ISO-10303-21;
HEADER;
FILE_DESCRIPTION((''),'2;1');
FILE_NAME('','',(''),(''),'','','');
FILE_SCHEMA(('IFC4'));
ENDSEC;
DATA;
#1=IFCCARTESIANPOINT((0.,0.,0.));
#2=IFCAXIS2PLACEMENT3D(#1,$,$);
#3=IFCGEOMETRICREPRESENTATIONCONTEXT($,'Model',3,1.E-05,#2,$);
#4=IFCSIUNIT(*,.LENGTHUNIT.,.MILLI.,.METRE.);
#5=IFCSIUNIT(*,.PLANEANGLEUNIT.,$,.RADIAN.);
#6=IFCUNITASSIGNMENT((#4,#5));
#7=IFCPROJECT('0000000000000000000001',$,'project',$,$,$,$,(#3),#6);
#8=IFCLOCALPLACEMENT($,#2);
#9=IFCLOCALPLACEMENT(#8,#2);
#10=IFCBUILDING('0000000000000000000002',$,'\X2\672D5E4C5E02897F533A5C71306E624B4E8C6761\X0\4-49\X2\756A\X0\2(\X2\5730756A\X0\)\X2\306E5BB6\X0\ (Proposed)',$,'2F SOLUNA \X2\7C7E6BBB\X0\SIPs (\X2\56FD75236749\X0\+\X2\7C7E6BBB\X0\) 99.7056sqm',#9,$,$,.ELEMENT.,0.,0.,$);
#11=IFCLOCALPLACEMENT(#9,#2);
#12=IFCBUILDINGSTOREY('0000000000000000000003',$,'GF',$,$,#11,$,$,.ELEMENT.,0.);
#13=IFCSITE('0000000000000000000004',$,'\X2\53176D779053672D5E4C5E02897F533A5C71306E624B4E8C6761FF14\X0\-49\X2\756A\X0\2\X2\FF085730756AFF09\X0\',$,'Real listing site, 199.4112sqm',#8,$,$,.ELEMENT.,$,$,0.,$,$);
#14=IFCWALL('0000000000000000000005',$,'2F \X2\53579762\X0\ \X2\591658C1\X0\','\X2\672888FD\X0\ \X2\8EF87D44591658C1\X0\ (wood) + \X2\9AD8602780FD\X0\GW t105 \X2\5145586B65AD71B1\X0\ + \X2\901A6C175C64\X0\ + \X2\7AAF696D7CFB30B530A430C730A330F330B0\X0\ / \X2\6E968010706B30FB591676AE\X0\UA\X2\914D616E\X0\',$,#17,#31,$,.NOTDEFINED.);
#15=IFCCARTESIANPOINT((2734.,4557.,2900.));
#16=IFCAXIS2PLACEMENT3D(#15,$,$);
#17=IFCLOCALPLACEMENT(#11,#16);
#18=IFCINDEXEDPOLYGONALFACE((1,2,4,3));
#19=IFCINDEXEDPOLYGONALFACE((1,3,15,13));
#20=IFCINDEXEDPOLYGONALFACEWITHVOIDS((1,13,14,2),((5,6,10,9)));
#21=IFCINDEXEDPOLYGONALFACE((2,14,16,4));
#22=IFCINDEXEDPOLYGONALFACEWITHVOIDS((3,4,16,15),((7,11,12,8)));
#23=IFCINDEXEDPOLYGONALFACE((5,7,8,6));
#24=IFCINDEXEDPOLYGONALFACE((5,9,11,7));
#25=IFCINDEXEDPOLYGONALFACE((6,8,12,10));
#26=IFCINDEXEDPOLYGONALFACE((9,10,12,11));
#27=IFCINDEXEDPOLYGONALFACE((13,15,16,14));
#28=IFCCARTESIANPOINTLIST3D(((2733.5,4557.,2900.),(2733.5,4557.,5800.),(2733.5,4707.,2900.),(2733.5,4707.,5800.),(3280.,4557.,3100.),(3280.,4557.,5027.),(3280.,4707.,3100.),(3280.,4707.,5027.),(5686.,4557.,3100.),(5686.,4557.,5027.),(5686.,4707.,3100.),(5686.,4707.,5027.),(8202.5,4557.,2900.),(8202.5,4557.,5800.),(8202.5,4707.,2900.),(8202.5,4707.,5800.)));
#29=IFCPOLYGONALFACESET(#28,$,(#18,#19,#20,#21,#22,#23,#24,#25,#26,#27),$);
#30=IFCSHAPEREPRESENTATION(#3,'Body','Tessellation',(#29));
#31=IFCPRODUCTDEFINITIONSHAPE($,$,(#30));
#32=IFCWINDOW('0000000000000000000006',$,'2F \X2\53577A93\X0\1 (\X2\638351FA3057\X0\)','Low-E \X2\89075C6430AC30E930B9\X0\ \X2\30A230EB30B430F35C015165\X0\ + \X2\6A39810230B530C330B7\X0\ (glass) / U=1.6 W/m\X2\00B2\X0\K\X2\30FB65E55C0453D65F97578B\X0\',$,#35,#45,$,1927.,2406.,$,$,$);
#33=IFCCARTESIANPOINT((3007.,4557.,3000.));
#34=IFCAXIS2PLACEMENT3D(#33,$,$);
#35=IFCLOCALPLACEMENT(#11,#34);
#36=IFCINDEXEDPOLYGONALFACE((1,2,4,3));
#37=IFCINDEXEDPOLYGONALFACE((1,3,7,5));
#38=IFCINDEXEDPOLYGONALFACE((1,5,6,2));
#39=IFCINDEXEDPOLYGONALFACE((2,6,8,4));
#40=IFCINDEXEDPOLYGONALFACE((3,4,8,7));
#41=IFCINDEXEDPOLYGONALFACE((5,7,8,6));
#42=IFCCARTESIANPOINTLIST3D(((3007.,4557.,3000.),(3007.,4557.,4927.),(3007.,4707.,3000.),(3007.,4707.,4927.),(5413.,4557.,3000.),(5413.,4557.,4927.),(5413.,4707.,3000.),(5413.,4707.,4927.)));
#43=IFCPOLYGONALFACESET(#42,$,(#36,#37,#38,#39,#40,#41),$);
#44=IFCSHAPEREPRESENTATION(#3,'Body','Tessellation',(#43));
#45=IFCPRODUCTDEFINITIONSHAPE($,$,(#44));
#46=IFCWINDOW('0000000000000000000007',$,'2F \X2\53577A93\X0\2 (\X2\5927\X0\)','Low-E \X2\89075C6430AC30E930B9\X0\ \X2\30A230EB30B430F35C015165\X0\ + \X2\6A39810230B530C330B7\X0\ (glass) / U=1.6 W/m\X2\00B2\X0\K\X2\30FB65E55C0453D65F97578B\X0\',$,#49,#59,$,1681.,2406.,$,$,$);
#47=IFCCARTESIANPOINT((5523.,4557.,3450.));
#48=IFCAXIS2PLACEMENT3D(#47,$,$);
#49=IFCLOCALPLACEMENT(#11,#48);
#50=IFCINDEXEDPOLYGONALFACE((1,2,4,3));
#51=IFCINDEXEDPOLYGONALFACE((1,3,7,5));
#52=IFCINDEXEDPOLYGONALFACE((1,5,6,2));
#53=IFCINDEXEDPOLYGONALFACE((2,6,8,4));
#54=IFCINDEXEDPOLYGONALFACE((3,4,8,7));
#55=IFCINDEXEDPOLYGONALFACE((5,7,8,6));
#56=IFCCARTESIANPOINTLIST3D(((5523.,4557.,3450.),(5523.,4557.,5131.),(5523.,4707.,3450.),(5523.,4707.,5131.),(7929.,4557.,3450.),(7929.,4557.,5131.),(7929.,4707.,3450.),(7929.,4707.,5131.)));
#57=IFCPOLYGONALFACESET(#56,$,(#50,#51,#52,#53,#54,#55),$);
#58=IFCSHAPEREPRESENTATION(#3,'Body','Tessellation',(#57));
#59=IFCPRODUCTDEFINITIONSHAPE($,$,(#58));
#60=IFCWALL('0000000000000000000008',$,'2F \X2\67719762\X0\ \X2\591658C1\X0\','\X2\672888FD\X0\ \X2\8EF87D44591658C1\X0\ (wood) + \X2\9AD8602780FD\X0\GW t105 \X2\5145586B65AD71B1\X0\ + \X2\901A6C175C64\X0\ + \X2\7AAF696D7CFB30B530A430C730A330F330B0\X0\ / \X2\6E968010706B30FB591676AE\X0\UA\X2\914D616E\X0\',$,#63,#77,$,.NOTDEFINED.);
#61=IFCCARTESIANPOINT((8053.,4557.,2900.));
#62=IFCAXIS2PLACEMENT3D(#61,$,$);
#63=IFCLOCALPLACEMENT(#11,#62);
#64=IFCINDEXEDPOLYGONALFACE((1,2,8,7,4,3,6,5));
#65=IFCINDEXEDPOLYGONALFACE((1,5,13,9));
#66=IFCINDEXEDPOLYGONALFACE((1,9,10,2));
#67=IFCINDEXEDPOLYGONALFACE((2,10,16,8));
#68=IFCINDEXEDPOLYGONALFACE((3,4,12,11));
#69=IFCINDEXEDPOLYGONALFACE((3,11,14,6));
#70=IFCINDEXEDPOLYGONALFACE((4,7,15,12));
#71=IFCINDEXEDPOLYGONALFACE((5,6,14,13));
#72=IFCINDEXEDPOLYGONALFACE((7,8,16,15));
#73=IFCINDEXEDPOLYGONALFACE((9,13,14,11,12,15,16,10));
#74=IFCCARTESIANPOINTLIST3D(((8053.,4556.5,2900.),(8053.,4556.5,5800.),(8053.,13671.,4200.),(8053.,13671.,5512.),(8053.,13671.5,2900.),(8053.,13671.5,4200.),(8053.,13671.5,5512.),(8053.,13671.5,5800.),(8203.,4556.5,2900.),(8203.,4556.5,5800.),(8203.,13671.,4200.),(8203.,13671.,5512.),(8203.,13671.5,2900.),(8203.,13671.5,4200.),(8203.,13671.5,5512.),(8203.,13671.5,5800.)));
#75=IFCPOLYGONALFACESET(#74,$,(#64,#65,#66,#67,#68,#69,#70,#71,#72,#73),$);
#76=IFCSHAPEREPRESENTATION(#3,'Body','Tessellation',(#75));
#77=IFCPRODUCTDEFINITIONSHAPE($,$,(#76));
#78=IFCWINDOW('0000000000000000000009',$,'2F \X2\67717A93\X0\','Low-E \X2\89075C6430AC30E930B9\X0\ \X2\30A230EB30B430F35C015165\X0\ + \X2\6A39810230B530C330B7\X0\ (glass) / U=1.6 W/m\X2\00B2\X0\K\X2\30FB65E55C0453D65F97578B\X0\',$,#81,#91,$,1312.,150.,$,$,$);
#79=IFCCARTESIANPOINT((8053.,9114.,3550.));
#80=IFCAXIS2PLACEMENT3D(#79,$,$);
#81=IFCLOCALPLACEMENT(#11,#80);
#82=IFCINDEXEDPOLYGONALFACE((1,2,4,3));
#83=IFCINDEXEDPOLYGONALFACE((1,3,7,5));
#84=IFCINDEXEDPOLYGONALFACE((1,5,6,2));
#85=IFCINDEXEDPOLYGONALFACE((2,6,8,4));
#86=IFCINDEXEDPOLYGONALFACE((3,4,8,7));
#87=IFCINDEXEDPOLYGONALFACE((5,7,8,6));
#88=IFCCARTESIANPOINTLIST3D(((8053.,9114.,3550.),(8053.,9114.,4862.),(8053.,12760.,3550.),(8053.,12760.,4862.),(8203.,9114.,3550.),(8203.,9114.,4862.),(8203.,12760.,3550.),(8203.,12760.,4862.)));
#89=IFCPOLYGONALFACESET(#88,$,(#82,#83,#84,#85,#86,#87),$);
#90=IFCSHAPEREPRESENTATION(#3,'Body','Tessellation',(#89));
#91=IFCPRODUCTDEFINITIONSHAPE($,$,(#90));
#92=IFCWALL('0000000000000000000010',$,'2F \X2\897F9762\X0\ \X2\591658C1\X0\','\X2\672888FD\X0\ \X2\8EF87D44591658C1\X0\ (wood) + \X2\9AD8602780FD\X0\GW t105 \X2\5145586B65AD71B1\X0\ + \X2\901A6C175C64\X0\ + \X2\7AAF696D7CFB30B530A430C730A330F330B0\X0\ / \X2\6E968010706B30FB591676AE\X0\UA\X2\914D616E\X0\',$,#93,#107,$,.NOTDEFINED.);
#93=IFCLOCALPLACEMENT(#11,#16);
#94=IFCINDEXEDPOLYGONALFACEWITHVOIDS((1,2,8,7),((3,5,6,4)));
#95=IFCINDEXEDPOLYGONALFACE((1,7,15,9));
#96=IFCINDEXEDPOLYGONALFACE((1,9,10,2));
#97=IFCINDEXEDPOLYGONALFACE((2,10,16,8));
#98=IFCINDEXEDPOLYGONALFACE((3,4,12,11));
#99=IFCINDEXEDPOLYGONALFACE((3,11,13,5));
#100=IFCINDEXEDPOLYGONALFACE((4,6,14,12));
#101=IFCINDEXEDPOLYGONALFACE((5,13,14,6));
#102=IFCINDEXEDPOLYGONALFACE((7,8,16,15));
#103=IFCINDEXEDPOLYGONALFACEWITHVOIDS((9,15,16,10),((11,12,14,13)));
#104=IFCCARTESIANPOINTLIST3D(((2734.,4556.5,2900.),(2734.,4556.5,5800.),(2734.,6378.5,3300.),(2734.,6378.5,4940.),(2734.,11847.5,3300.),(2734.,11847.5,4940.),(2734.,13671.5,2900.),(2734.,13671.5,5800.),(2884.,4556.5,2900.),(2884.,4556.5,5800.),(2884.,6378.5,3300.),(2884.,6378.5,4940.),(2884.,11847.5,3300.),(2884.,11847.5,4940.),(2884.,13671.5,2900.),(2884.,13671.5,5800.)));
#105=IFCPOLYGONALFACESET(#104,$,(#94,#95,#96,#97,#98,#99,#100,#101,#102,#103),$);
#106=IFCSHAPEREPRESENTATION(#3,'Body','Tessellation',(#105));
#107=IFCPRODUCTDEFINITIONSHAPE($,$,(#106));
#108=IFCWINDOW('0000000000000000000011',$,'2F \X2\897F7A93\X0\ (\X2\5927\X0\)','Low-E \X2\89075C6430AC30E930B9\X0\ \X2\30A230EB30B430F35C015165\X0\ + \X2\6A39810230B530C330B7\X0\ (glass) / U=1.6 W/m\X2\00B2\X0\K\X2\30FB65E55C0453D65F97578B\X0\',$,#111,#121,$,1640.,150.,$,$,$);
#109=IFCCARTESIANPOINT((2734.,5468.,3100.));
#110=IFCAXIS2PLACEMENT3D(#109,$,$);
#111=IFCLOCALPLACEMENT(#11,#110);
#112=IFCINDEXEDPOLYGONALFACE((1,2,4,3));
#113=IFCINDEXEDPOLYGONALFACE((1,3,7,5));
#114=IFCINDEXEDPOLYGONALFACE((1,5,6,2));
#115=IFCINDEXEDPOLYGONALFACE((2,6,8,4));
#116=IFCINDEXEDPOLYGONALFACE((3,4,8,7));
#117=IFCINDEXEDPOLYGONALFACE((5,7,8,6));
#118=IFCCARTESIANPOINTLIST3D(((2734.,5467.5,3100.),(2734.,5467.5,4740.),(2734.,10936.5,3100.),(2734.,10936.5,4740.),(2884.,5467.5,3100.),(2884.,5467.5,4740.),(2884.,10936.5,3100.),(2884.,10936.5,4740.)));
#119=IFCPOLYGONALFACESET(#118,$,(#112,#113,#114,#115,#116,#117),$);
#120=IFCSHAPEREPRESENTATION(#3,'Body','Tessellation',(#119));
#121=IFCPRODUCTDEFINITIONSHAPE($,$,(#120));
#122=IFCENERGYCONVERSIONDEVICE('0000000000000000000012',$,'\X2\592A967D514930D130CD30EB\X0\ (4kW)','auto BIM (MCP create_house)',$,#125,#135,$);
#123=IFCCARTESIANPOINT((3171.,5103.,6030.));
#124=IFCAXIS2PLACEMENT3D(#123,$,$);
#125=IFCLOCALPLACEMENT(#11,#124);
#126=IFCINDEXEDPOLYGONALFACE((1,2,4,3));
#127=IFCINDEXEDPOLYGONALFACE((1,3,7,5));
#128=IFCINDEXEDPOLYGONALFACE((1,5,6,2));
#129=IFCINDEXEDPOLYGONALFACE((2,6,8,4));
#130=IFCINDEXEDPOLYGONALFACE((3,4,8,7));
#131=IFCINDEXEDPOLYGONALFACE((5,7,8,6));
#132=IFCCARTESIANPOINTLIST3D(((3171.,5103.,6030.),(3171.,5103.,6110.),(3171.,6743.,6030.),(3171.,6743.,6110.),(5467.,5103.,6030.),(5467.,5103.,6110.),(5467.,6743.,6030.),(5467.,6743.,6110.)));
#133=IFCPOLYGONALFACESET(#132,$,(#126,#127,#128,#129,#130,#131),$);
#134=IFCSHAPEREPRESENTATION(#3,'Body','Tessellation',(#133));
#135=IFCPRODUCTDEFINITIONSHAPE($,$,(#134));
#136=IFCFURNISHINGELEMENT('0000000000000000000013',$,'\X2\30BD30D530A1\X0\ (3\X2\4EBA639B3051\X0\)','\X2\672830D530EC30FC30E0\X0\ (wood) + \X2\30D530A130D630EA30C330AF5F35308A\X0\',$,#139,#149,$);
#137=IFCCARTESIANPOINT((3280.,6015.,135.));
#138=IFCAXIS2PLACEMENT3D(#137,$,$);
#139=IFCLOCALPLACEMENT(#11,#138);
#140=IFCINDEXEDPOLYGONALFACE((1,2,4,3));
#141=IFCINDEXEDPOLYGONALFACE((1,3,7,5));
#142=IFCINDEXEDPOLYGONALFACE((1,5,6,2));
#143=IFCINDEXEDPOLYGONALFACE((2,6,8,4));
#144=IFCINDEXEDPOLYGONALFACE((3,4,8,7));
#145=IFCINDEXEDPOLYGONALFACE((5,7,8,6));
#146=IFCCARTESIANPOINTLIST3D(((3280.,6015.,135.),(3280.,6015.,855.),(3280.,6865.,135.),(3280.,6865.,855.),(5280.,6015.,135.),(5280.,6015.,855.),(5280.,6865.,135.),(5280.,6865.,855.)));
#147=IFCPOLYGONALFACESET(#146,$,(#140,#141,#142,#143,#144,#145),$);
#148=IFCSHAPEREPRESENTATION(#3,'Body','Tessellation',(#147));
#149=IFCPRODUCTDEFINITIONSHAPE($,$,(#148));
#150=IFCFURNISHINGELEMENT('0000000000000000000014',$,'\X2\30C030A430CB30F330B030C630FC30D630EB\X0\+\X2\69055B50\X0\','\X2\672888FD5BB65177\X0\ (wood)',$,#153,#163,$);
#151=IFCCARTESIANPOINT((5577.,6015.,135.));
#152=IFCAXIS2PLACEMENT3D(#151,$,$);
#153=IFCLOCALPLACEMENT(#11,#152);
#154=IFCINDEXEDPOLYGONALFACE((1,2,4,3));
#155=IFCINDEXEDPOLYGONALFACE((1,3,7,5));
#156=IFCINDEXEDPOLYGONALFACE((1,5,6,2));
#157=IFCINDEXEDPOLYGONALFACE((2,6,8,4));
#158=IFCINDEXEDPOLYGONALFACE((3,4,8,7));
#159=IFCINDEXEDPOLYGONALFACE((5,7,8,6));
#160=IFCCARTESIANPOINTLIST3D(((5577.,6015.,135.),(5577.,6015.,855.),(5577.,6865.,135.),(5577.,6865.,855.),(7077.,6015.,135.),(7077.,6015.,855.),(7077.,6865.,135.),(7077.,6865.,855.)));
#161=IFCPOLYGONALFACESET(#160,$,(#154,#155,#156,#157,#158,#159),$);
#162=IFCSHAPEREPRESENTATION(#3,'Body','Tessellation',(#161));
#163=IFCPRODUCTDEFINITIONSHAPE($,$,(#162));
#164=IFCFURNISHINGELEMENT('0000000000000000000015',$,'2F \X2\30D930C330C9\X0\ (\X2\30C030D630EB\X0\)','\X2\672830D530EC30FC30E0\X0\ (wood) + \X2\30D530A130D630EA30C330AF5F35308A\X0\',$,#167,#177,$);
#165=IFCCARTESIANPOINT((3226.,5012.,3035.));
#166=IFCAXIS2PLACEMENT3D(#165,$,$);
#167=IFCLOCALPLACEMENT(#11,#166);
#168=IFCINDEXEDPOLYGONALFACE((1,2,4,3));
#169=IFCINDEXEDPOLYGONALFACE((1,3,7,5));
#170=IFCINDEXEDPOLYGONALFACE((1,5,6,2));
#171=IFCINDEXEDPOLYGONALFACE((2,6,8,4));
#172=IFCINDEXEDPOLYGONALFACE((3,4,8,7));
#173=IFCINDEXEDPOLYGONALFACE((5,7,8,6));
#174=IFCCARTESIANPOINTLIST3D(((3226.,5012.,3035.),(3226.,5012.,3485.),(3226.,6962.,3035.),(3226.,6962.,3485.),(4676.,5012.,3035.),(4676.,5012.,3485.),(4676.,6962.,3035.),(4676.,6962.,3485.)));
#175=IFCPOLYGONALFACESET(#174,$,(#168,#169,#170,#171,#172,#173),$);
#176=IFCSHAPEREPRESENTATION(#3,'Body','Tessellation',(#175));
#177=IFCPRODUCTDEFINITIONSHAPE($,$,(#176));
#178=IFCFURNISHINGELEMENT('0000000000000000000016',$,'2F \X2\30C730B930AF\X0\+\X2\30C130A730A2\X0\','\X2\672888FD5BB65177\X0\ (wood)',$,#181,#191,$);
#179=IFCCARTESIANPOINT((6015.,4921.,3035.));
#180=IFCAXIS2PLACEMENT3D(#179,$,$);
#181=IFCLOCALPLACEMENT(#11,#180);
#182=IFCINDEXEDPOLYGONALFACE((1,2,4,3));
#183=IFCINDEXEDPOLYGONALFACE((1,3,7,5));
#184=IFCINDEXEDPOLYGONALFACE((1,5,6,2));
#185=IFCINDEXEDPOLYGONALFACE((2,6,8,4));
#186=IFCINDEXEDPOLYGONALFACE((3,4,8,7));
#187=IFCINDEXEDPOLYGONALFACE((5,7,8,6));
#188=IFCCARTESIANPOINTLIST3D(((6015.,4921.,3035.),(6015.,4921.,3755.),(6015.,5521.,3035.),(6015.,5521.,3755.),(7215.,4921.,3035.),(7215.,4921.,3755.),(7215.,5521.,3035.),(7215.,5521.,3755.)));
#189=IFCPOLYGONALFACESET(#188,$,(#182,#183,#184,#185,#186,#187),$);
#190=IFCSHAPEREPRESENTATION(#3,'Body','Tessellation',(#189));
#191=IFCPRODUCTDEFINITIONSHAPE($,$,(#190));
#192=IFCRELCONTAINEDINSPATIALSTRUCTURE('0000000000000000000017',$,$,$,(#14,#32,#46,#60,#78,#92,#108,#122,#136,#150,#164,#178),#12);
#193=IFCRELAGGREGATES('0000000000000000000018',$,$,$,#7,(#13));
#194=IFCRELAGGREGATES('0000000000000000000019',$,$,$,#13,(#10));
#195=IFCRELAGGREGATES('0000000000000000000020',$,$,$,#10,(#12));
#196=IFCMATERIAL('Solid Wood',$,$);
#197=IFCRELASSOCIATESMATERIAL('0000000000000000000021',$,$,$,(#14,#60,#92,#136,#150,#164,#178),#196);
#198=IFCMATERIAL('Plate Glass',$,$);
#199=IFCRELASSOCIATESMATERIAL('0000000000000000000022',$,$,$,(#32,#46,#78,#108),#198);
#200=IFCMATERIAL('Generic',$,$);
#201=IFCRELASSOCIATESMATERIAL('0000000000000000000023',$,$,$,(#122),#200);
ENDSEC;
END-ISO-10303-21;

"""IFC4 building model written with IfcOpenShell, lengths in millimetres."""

from ifc_helpers import new_model, si_unit, frame, frame_2d, origin, place, context, project, spatial, rectangle, extrude, material, element, fill, save


model = new_model("IFC4")

# Units and contexts
model_context = context("Model", 3, precision=1e-05, world=origin())
ifc_project = project(units=[si_unit("LENGTHUNIT", "METRE", prefix="MILLI"), si_unit("PLANEANGLEUNIT", "RADIAN")], contexts=[model_context])

# Site, building, storey
site_placement = place(None, origin())
site = spatial("IfcSite", under=ifc_project, at=site_placement, Name="北海道札幌市西区山の手二条４-49番2（地番）", ObjectType="Real listing site, 199.4112sqm", CompositionType="ELEMENT", RefElevation=0.0)
building_placement = place(site_placement, origin())
building = spatial("IfcBuilding", under=site, at=building_placement, Name="札幌市西区山の手二条4-49番2(地番)の家 (Proposed)", ObjectType="2F SOLUNA 籾殻SIPs (国産杉+籾殻) 99.7056sqm", CompositionType="ELEMENT", ElevationOfRefHeight=0.0, ElevationOfTerrain=0.0)
storey_placement = place(building_placement, origin())
storey = spatial("IfcBuildingStorey", under=building, at=storey_placement, Name="GF", CompositionType="ELEMENT", Elevation=0.0)

# Shared definitions
ifc_material_1 = material(Name="Solid Wood")

# Wall, openings, windows
wall_1_placement = place(storey_placement, frame((2734.0, 4557.0, 2900.0)))
wall_1 = element("IfcWall", 1, at=wall_1_placement, inside=storey, material=ifc_material_1, Name="2F 南面 外壁", Description="木製 軸組外壁 (wood) + 高性能GW t105 充填断熱 + 通気層 + 窯業系サイディング / 準耐火・外皮UA配慮", PredefinedType="NOTDEFINED", context=model_context, shape_type="SweptSolid", body=[
    extrude(rectangle(XDim=5469.0, YDim=150.0, at=frame_2d((2734.0, 75.0))), frame((2734.0, 4557.0, 2900.0)), (0.0, 0.0, 1.0), 2900.0),
])
opening_1_placement = place(storey_placement, frame((3007.0, 4557.0, 3000.0)))
opening_1 = element("IfcOpeningElement", 2, at=opening_1_placement, cuts=wall_1, PredefinedType="NOTDEFINED", context=model_context, shape_type="SweptSolid", body=[
    extrude(rectangle(XDim=2406.0, YDim=150.0, at=frame_2d((1203.0, 75.0))), frame((3007.0, 4557.0, 3000.0)), (0.0, 0.0, 1.0), 1927.0),
])
opening_2_placement = place(storey_placement, frame((5523.0, 4557.0, 3450.0)))
opening_2 = element("IfcOpeningElement", 3, at=opening_2_placement, cuts=wall_1, PredefinedType="NOTDEFINED", context=model_context, shape_type="SweptSolid", body=[
    extrude(rectangle(XDim=2406.0, YDim=150.0, at=frame_2d((1203.0, 75.0))), frame((5523.0, 4557.0, 3450.0)), (0.0, 0.0, 1.0), 1681.0),
])
ifc_material_2 = material(Name="Plate Glass")
window_1_placement = place(storey_placement, frame((3007.0, 4557.0, 3000.0)))
window_1 = element("IfcWindow", 4, at=window_1_placement, inside=storey, material=ifc_material_2, Name="2F 南窓1 (掃出し)", Description="Low-E 複層ガラス アルゴン封入 + 樹脂サッシ (glass) / U=1.6 W/m²K・日射取得型", OverallHeight=1927.0, OverallWidth=2406.0, context=model_context, shape_type="SweptSolid", body=[
    extrude(rectangle(XDim=2406.0, YDim=150.0, at=frame_2d((1203.0, 75.0))), frame((3007.0, 4557.0, 3000.0)), (0.0, 0.0, 1.0), 1927.0),
])
fill(opening_1, window_1)
window_2_placement = place(storey_placement, frame((5523.0, 4557.0, 3450.0)))
window_2 = element("IfcWindow", 5, at=window_2_placement, inside=storey, material=ifc_material_2, Name="2F 南窓2 (大)", Description="Low-E 複層ガラス アルゴン封入 + 樹脂サッシ (glass) / U=1.6 W/m²K・日射取得型", OverallHeight=1681.0, OverallWidth=2406.0, context=model_context, shape_type="SweptSolid", body=[
    extrude(rectangle(XDim=2406.0, YDim=150.0, at=frame_2d((1203.0, 75.0))), frame((5523.0, 4557.0, 3450.0)), (0.0, 0.0, 1.0), 1681.0),
])
fill(opening_2, window_2)

# Walls, openings, windows
wall_2_placement = place(storey_placement, frame((8053.0, 4557.0, 2900.0)))
wall_2 = element("IfcWall", 6, at=wall_2_placement, inside=storey, material=ifc_material_1, Name="2F 東面 外壁", Description="木製 軸組外壁 (wood) + 高性能GW t105 充填断熱 + 通気層 + 窯業系サイディング / 準耐火・外皮UA配慮", PredefinedType="NOTDEFINED", context=model_context, shape_type="SweptSolid", body=[
    extrude(rectangle(XDim=150.0, YDim=9115.0, at=frame_2d((75.0, 4557.0))), frame((8053.0, 4557.0, 2900.0)), (0.0, 0.0, 1.0), 2900.0),
])
opening_3_placement = place(storey_placement, frame((8053.0, 9114.0, 3550.0)))
opening_3 = element("IfcOpeningElement", 7, at=opening_3_placement, cuts=wall_2, PredefinedType="NOTDEFINED", context=model_context, shape_type="SweptSolid", body=[
    extrude(rectangle(XDim=150.0, YDim=3646.0, at=frame_2d((75.0, 1823.0))), frame((8053.0, 9114.0, 3550.0)), (0.0, 0.0, 1.0), 1312.0),
])
window_3_placement = place(storey_placement, frame((8053.0, 9114.0, 3550.0)))
window_3 = element("IfcWindow", 8, at=window_3_placement, inside=storey, material=ifc_material_2, Name="2F 東窓", Description="Low-E 複層ガラス アルゴン封入 + 樹脂サッシ (glass) / U=1.6 W/m²K・日射取得型", OverallHeight=1312.0, OverallWidth=150.0, context=model_context, shape_type="SweptSolid", body=[
    extrude(rectangle(XDim=150.0, YDim=3646.0, at=frame_2d((75.0, 1823.0))), frame((8053.0, 9114.0, 3550.0)), (0.0, 0.0, 1.0), 1312.0),
])
fill(opening_3, window_3)
wall_3_placement = place(storey_placement, frame((2734.0, 4557.0, 2900.0)))
wall_3 = element("IfcWall", 9, at=wall_3_placement, inside=storey, material=ifc_material_1, Name="2F 西面 外壁", Description="木製 軸組外壁 (wood) + 高性能GW t105 充填断熱 + 通気層 + 窯業系サイディング / 準耐火・外皮UA配慮", PredefinedType="NOTDEFINED", context=model_context, shape_type="SweptSolid", body=[
    extrude(rectangle(XDim=150.0, YDim=9115.0, at=frame_2d((75.0, 4557.0))), frame((2734.0, 4557.0, 2900.0)), (0.0, 0.0, 1.0), 2900.0),
])
opening_4_placement = place(storey_placement, frame((2734.0, 5468.0, 3100.0)))
opening_4 = element("IfcOpeningElement", 10, at=opening_4_placement, cuts=wall_3, PredefinedType="NOTDEFINED", context=model_context, shape_type="SweptSolid", body=[
    extrude(rectangle(XDim=150.0, YDim=5469.0, at=frame_2d((75.0, 2734.0))), frame((2734.0, 5468.0, 3100.0)), (0.0, 0.0, 1.0), 1640.0),
])
window_4_placement = place(storey_placement, frame((2734.0, 5468.0, 3100.0)))
window_4 = element("IfcWindow", 11, at=window_4_placement, inside=storey, material=ifc_material_2, Name="2F 西窓 (大)", Description="Low-E 複層ガラス アルゴン封入 + 樹脂サッシ (glass) / U=1.6 W/m²K・日射取得型", OverallHeight=1640.0, OverallWidth=150.0, context=model_context, shape_type="SweptSolid", body=[
    extrude(rectangle(XDim=150.0, YDim=5469.0, at=frame_2d((75.0, 2734.0))), frame((2734.0, 5468.0, 3100.0)), (0.0, 0.0, 1.0), 1640.0),
])
fill(opening_4, window_4)

# Shared definitions
ifc_material_3 = material(Name="Generic")

# Energy conversion device
energy_conversion_device_placement = place(storey_placement, frame((3171.0, 5103.0, 6030.0)))
element("IfcEnergyConversionDevice", 12, at=energy_conversion_device_placement, inside=storey, material=ifc_material_3, Name="太陽光パネル (4kW)", Description="auto BIM (MCP create_house)", context=model_context, shape_type="SweptSolid", body=[
    extrude(rectangle(XDim=2296.0, YDim=1640.0, at=frame_2d((1148.0, 820.0))), frame((3171.0, 5103.0, 6030.0)), (0.0, 0.0, 1.0), 80.0),
])

# Furnishing elements
furnishing_1_placement = place(storey_placement, frame((3280.0, 6015.0, 135.0)))
element("IfcFurnishingElement", 13, at=furnishing_1_placement, inside=storey, material=ifc_material_1, Name="ソファ (3人掛け)", Description="木フレーム (wood) + ファブリック張り", context=model_context, shape_type="SweptSolid", body=[
    extrude(rectangle(XDim=2000.0, YDim=850.0, at=frame_2d((1000.0, 425.0))), frame((3280.0, 6015.0, 135.0)), (0.0, 0.0, 1.0), 720.0),
])
furnishing_2_placement = place(storey_placement, frame((5577.0, 6015.0, 135.0)))
element("IfcFurnishingElement", 14, at=furnishing_2_placement, inside=storey, material=ifc_material_1, Name="ダイニングテーブル+椅子", Description="木製家具 (wood)", context=model_context, shape_type="SweptSolid", body=[
    extrude(rectangle(XDim=1500.0, YDim=850.0, at=frame_2d((750.0, 425.0))), frame((5577.0, 6015.0, 135.0)), (0.0, 0.0, 1.0), 720.0),
])
furnishing_3_placement = place(storey_placement, frame((3226.0, 5012.0, 3035.0)))
element("IfcFurnishingElement", 15, at=furnishing_3_placement, inside=storey, material=ifc_material_1, Name="2F ベッド (ダブル)", Description="木フレーム (wood) + ファブリック張り", context=model_context, shape_type="SweptSolid", body=[
    extrude(rectangle(XDim=1450.0, YDim=1950.0, at=frame_2d((725.0, 975.0))), frame((3226.0, 5012.0, 3035.0)), (0.0, 0.0, 1.0), 450.0),
])
furnishing_4_placement = place(storey_placement, frame((6015.0, 4921.0, 3035.0)))
element("IfcFurnishingElement", 16, at=furnishing_4_placement, inside=storey, material=ifc_material_1, Name="2F デスク+チェア", Description="木製家具 (wood)", context=model_context, shape_type="SweptSolid", body=[
    extrude(rectangle(XDim=1200.0, YDim=600.0, at=frame_2d((600.0, 300.0))), frame((6015.0, 4921.0, 3035.0)), (0.0, 0.0, 1.0), 720.0),
])

save(model, "model.ifc")
